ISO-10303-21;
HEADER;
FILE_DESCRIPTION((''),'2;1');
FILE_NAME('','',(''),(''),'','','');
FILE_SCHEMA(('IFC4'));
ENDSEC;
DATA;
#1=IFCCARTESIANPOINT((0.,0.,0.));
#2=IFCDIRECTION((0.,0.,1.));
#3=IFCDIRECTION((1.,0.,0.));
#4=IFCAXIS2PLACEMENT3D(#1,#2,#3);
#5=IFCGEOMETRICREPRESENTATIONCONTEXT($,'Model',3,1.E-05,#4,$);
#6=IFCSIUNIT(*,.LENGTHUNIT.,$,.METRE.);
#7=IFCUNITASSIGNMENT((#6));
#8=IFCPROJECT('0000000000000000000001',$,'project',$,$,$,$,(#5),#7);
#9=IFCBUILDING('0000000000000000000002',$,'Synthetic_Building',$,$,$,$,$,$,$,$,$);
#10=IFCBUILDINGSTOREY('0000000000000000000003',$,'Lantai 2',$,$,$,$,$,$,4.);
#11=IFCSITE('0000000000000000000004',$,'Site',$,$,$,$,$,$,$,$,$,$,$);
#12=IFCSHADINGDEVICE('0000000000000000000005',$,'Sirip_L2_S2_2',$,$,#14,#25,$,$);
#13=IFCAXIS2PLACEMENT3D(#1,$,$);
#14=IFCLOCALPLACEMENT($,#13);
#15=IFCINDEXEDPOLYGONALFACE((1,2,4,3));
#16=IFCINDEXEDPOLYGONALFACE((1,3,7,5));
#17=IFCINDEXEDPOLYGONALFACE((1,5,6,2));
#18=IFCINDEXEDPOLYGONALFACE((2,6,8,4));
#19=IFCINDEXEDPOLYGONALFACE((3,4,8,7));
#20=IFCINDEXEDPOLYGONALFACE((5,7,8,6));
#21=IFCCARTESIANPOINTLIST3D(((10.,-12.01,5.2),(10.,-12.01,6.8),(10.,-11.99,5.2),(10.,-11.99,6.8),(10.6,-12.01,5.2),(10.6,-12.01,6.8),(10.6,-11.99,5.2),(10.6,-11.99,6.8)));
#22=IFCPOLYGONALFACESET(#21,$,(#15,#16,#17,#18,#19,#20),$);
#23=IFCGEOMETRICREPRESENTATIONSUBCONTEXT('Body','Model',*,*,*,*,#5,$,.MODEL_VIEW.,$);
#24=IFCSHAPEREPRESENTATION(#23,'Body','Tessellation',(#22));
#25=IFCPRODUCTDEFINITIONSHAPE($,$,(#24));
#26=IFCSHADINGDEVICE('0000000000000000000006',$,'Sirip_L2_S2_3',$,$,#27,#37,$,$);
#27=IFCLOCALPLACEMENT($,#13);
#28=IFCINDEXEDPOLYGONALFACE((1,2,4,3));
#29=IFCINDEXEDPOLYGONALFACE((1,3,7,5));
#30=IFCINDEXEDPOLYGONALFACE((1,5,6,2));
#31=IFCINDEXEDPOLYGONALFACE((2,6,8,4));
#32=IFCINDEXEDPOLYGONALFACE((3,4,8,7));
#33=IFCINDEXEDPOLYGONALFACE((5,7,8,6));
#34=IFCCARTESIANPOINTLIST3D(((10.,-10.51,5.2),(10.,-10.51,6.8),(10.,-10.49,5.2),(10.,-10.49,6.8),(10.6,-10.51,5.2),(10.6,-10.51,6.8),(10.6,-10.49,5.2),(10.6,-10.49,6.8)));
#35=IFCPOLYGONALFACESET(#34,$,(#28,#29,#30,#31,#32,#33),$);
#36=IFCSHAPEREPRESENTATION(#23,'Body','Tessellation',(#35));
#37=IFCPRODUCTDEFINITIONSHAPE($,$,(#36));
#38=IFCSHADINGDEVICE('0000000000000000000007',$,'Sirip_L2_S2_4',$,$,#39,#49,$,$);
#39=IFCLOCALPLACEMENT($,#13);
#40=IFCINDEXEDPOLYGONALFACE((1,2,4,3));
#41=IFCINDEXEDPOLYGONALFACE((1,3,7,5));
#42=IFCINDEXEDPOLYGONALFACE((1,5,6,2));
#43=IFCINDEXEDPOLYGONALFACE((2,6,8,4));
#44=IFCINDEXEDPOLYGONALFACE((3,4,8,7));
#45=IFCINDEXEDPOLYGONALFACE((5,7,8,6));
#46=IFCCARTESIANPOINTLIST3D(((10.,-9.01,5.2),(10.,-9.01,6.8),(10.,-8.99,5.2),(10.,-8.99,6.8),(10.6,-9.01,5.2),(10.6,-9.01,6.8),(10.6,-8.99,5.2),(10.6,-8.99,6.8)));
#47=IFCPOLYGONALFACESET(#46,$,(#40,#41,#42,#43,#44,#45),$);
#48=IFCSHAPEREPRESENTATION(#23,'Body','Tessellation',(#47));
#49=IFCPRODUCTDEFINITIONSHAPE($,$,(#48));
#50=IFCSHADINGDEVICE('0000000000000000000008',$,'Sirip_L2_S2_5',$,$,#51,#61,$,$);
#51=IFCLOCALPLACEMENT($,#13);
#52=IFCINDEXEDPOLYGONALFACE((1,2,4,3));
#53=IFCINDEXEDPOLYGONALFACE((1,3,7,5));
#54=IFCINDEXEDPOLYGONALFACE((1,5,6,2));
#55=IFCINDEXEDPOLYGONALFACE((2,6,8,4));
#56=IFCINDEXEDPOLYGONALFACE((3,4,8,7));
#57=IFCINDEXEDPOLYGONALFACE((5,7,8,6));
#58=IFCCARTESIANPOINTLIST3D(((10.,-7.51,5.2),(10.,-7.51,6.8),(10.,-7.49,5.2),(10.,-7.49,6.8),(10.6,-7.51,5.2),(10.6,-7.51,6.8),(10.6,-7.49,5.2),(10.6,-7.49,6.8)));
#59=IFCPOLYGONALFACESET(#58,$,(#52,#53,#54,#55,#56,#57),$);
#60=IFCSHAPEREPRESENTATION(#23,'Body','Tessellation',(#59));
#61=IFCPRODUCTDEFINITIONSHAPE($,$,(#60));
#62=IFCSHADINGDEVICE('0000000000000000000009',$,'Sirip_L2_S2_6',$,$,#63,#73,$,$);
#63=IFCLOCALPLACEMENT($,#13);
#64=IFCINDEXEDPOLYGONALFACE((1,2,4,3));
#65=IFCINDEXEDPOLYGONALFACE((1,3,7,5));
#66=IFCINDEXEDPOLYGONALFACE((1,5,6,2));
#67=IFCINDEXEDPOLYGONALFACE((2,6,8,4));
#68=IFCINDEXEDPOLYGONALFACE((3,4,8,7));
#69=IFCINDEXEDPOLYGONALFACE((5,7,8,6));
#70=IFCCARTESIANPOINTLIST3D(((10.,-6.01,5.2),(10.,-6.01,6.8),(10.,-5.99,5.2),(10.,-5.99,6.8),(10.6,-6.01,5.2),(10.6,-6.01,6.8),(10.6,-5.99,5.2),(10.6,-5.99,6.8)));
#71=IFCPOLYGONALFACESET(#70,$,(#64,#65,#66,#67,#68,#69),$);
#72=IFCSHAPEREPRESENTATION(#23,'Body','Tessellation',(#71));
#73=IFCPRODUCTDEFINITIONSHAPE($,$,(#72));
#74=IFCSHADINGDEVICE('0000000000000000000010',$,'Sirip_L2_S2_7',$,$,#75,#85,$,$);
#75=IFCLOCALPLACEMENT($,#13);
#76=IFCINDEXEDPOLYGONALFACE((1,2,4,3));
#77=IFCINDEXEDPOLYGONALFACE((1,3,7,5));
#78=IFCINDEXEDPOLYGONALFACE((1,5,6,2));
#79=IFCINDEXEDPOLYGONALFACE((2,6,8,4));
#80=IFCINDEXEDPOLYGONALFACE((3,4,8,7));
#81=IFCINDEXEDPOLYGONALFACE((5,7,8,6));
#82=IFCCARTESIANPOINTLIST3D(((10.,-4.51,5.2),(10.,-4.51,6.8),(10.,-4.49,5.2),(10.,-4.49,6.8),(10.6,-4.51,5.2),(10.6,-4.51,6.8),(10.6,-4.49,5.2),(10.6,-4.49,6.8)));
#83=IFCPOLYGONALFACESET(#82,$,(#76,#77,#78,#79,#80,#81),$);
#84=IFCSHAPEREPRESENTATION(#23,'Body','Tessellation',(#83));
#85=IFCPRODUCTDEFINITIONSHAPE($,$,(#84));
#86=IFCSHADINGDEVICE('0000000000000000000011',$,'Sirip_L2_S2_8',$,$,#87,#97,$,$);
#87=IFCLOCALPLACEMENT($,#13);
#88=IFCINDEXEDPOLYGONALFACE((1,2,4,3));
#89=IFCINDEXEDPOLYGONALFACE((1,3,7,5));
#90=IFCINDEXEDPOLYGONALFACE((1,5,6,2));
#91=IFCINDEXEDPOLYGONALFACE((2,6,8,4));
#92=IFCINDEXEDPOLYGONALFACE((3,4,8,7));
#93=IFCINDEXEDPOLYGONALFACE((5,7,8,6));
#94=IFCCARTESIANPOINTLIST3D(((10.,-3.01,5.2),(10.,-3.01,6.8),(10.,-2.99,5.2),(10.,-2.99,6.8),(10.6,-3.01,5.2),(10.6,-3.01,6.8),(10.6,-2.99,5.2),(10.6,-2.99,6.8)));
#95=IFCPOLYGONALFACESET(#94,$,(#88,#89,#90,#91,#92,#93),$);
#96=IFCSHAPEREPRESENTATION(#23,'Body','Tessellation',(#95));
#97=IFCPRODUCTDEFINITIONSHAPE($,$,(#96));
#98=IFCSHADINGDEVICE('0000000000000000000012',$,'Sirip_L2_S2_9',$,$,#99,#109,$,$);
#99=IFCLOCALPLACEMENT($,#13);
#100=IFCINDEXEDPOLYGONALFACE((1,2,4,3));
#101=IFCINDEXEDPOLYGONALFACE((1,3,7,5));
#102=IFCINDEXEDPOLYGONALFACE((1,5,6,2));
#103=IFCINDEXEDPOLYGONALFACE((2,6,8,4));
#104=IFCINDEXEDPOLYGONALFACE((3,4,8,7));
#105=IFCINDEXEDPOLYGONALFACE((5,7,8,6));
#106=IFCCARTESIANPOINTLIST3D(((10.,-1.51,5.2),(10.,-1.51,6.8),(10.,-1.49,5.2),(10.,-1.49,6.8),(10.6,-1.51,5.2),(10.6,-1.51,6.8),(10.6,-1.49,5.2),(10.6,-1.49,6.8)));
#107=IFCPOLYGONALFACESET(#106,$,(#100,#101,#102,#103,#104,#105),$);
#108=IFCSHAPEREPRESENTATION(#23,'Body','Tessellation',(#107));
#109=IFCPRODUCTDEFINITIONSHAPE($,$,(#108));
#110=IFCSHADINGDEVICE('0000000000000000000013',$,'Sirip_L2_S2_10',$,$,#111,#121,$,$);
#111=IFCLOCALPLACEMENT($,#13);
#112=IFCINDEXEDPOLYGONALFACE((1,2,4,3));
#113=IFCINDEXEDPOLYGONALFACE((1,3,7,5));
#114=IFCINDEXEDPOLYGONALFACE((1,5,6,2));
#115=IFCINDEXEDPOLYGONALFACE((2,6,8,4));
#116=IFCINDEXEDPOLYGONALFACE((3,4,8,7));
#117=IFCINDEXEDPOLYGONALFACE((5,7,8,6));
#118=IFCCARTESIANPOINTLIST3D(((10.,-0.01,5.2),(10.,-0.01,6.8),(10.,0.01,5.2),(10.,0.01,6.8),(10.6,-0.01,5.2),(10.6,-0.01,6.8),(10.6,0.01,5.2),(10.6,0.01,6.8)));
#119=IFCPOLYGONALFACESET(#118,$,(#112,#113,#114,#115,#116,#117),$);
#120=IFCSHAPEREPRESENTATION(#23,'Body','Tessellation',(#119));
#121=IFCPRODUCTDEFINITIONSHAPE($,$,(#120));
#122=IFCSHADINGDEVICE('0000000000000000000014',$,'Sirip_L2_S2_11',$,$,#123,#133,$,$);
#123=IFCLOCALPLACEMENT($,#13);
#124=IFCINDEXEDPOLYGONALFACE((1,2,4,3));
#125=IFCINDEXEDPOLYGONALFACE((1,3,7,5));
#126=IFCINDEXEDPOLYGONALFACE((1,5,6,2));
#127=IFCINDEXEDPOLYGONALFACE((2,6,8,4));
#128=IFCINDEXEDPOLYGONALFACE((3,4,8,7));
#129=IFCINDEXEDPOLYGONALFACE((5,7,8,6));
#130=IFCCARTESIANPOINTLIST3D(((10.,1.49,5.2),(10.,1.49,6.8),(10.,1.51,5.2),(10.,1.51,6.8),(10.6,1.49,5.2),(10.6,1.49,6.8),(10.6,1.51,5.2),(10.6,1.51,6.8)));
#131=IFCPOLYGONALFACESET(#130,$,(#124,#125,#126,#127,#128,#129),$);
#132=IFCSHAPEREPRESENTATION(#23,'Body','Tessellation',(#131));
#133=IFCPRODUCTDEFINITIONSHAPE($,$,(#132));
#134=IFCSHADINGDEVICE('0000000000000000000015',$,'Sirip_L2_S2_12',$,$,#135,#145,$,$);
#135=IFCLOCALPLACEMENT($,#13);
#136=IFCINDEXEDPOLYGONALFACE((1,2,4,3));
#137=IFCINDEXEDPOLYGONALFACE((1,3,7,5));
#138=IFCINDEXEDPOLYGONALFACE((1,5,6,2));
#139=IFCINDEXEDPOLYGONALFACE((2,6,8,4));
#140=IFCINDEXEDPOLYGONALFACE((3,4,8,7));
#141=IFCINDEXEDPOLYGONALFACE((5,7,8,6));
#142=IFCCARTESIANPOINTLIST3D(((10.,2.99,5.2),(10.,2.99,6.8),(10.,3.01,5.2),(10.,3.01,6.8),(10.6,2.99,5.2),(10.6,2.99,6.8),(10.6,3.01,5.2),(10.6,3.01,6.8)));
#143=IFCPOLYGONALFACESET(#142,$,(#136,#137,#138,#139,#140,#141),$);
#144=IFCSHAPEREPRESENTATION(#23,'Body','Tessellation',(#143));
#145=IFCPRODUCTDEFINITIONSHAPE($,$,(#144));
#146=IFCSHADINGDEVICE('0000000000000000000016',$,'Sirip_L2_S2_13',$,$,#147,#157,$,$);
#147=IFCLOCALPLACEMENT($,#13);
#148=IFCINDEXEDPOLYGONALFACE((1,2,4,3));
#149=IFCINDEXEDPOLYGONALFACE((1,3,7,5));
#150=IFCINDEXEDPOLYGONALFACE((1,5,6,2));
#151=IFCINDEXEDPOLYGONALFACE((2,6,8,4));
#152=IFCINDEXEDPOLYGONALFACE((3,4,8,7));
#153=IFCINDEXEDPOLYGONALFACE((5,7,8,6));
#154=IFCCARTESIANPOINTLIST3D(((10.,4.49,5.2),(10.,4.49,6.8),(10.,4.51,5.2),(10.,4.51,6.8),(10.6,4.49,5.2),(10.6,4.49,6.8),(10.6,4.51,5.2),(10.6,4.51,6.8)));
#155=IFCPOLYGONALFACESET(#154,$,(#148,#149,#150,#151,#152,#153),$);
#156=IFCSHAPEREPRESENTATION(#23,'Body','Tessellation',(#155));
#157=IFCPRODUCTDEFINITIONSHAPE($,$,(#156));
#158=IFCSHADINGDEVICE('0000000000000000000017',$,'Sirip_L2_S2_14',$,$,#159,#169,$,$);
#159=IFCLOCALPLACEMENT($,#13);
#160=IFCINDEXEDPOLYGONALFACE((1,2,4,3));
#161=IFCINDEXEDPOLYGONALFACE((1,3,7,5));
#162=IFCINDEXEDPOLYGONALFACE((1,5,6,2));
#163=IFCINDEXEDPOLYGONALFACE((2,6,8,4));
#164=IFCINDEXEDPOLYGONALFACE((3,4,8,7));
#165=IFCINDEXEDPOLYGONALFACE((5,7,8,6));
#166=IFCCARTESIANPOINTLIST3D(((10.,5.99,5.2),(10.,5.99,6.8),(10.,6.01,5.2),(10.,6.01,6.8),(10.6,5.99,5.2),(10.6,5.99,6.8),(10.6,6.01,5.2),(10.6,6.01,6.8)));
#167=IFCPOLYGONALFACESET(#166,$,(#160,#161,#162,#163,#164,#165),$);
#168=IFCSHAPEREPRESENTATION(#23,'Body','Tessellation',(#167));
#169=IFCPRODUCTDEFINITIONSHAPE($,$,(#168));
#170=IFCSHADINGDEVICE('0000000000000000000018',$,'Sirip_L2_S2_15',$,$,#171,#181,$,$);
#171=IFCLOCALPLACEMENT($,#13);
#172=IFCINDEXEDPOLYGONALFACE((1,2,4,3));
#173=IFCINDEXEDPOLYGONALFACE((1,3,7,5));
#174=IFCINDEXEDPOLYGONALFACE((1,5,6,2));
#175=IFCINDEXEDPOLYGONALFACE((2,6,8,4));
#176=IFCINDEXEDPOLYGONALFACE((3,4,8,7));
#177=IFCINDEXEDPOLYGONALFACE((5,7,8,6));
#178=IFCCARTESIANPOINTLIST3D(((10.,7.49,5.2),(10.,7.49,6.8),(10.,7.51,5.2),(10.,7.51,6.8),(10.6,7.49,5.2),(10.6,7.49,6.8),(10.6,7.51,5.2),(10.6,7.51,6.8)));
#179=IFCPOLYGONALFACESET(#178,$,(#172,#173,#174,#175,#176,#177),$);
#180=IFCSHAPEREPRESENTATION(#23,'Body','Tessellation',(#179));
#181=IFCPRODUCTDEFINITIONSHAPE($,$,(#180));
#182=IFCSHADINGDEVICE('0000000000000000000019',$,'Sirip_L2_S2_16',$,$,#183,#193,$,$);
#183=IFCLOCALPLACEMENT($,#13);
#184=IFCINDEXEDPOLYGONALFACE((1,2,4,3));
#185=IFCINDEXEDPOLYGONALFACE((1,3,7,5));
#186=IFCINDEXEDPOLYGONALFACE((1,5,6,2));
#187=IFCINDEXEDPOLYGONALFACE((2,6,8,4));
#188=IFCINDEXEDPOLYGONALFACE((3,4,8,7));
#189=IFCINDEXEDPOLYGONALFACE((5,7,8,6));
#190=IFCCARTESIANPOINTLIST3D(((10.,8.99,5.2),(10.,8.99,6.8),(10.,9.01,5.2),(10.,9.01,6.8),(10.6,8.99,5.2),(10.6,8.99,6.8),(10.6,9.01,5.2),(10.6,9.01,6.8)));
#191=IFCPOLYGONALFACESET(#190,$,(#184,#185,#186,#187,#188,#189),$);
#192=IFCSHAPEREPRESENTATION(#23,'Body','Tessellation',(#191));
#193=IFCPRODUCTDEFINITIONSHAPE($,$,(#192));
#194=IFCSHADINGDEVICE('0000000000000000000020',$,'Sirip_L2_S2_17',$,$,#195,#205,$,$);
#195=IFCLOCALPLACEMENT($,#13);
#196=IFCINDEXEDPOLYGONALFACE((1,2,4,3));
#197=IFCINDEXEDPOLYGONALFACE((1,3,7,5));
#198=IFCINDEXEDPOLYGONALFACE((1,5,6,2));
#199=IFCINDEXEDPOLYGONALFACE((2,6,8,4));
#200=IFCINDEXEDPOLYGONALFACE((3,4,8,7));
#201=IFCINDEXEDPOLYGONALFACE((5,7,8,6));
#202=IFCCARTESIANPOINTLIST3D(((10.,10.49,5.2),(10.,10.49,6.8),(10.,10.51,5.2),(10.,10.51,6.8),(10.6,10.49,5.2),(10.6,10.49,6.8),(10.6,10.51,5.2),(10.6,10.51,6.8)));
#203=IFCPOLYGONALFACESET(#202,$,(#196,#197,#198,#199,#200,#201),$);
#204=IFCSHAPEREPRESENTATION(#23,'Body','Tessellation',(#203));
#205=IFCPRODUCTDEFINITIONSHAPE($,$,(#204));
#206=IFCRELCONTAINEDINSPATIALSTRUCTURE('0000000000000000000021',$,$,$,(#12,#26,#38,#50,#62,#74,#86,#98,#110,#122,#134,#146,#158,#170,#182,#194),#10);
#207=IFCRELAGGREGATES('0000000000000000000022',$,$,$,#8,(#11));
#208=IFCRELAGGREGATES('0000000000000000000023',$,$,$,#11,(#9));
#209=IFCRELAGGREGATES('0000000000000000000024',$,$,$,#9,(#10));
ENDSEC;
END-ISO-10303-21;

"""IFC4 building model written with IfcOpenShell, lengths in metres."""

from ifc_helpers import new_model, si_unit, frame, origin_with_axes, place, context, subcontext, project, spatial, polyline, outline, extrude, element, save


model = new_model("IFC4")

# Units and contexts
model_context = context("Model", 3, precision=1e-05, world=origin_with_axes())
body_context = subcontext(model_context, "Body", "Model", "MODEL_VIEW")
ifc_project = project(units=[si_unit("LENGTHUNIT", "METRE")], contexts=[model_context])

# Site, building, storey
site = spatial("IfcSite", under=ifc_project, Name="Site")
building = spatial("IfcBuilding", under=site, Name="Synthetic_Building")
storey = spatial("IfcBuildingStorey", under=building, Name="Lantai 2", Elevation=4.0)

# Shading devices
shading_device_1_placement = place(None, origin_with_axes())
element("IfcShadingDevice", 1, at=shading_device_1_placement, inside=storey, Name="Sirip_L2_S2_2", context=body_context, shape_type="SweptSolid", body=[
    extrude(outline(polyline([(10.0, -12.01), (10.0, -11.99), (10.6, -11.99), (10.6, -12.01), (10.0, -12.01)])), frame((0.0, 0.0, 5.2), z_axis=(0.0, 0.0, 1.0), x_axis=(1.0, 0.0, 0.0)), (0.0, 0.0, 1.0), 1.6),
])
shading_device_2_placement = place(None, origin_with_axes())
element("IfcShadingDevice", 2, at=shading_device_2_placement, inside=storey, Name="Sirip_L2_S2_3", context=body_context, shape_type="SweptSolid", body=[
    extrude(outline(polyline([(10.0, -10.51), (10.0, -10.49), (10.6, -10.49), (10.6, -10.51), (10.0, -10.51)])), frame((0.0, 0.0, 5.2), z_axis=(0.0, 0.0, 1.0), x_axis=(1.0, 0.0, 0.0)), (0.0, 0.0, 1.0), 1.6),
])
shading_device_3_placement = place(None, origin_with_axes())
element("IfcShadingDevice", 3, at=shading_device_3_placement, inside=storey, Name="Sirip_L2_S2_4", context=body_context, shape_type="SweptSolid", body=[
    extrude(outline(polyline([(10.0, -9.01), (10.0, -8.99), (10.6, -8.99), (10.6, -9.01), (10.0, -9.01)])), frame((0.0, 0.0, 5.2), z_axis=(0.0, 0.0, 1.0), x_axis=(1.0, 0.0, 0.0)), (0.0, 0.0, 1.0), 1.6),
])
shading_device_4_placement = place(None, origin_with_axes())
element("IfcShadingDevice", 4, at=shading_device_4_placement, inside=storey, Name="Sirip_L2_S2_5", context=body_context, shape_type="SweptSolid", body=[
    extrude(outline(polyline([(10.0, -7.51), (10.0, -7.49), (10.6, -7.49), (10.6, -7.51), (10.0, -7.51)])), frame((0.0, 0.0, 5.2), z_axis=(0.0, 0.0, 1.0), x_axis=(1.0, 0.0, 0.0)), (0.0, 0.0, 1.0), 1.6),
])
shading_device_5_placement = place(None, origin_with_axes())
element("IfcShadingDevice", 5, at=shading_device_5_placement, inside=storey, Name="Sirip_L2_S2_6", context=body_context, shape_type="SweptSolid", body=[
    extrude(outline(polyline([(10.0, -6.01), (10.0, -5.99), (10.6, -5.99), (10.6, -6.01), (10.0, -6.01)])), frame((0.0, 0.0, 5.2), z_axis=(0.0, 0.0, 1.0), x_axis=(1.0, 0.0, 0.0)), (0.0, 0.0, 1.0), 1.6),
])
shading_device_6_placement = place(None, origin_with_axes())
element("IfcShadingDevice", 6, at=shading_device_6_placement, inside=storey, Name="Sirip_L2_S2_7", context=body_context, shape_type="SweptSolid", body=[
    extrude(outline(polyline([(10.0, -4.51), (10.0, -4.49), (10.6, -4.49), (10.6, -4.51), (10.0, -4.51)])), frame((0.0, 0.0, 5.2), z_axis=(0.0, 0.0, 1.0), x_axis=(1.0, 0.0, 0.0)), (0.0, 0.0, 1.0), 1.6),
])
shading_device_7_placement = place(None, origin_with_axes())
element("IfcShadingDevice", 7, at=shading_device_7_placement, inside=storey, Name="Sirip_L2_S2_8", context=body_context, shape_type="SweptSolid", body=[
    extrude(outline(polyline([(10.0, -3.01), (10.0, -2.99), (10.6, -2.99), (10.6, -3.01), (10.0, -3.01)])), frame((0.0, 0.0, 5.2), z_axis=(0.0, 0.0, 1.0), x_axis=(1.0, 0.0, 0.0)), (0.0, 0.0, 1.0), 1.6),
])
shading_device_8_placement = place(None, origin_with_axes())
element("IfcShadingDevice", 8, at=shading_device_8_placement, inside=storey, Name="Sirip_L2_S2_9", context=body_context, shape_type="SweptSolid", body=[
    extrude(outline(polyline([(10.0, -1.51), (10.0, -1.49), (10.6, -1.49), (10.6, -1.51), (10.0, -1.51)])), frame((0.0, 0.0, 5.2), z_axis=(0.0, 0.0, 1.0), x_axis=(1.0, 0.0, 0.0)), (0.0, 0.0, 1.0), 1.6),
])
shading_device_9_placement = place(None, origin_with_axes())
element("IfcShadingDevice", 9, at=shading_device_9_placement, inside=storey, Name="Sirip_L2_S2_10", context=body_context, shape_type="SweptSolid", body=[
    extrude(outline(polyline([(10.0, -0.01), (10.0, 0.01), (10.6, 0.01), (10.6, -0.01), (10.0, -0.01)])), frame((0.0, 0.0, 5.2), z_axis=(0.0, 0.0, 1.0), x_axis=(1.0, 0.0, 0.0)), (0.0, 0.0, 1.0), 1.6),
])
shading_device_10_placement = place(None, origin_with_axes())
element("IfcShadingDevice", 10, at=shading_device_10_placement, inside=storey, Name="Sirip_L2_S2_11", context=body_context, shape_type="SweptSolid", body=[
    extrude(outline(polyline([(10.0, 1.49), (10.0, 1.51), (10.6, 1.51), (10.6, 1.49), (10.0, 1.49)])), frame((0.0, 0.0, 5.2), z_axis=(0.0, 0.0, 1.0), x_axis=(1.0, 0.0, 0.0)), (0.0, 0.0, 1.0), 1.6),
])
shading_device_11_placement = place(None, origin_with_axes())
element("IfcShadingDevice", 11, at=shading_device_11_placement, inside=storey, Name="Sirip_L2_S2_12", context=body_context, shape_type="SweptSolid", body=[
    extrude(outline(polyline([(10.0, 2.99), (10.0, 3.01), (10.6, 3.01), (10.6, 2.99), (10.0, 2.99)])), frame((0.0, 0.0, 5.2), z_axis=(0.0, 0.0, 1.0), x_axis=(1.0, 0.0, 0.0)), (0.0, 0.0, 1.0), 1.6),
])
shading_device_12_placement = place(None, origin_with_axes())
element("IfcShadingDevice", 12, at=shading_device_12_placement, inside=storey, Name="Sirip_L2_S2_13", context=body_context, shape_type="SweptSolid", body=[
    extrude(outline(polyline([(10.0, 4.49), (10.0, 4.51), (10.6, 4.51), (10.6, 4.49), (10.0, 4.49)])), frame((0.0, 0.0, 5.2), z_axis=(0.0, 0.0, 1.0), x_axis=(1.0, 0.0, 0.0)), (0.0, 0.0, 1.0), 1.6),
])
shading_device_13_placement = place(None, origin_with_axes())
element("IfcShadingDevice", 13, at=shading_device_13_placement, inside=storey, Name="Sirip_L2_S2_14", context=body_context, shape_type="SweptSolid", body=[
    extrude(outline(polyline([(10.0, 5.99), (10.0, 6.01), (10.6, 6.01), (10.6, 5.99), (10.0, 5.99)])), frame((0.0, 0.0, 5.2), z_axis=(0.0, 0.0, 1.0), x_axis=(1.0, 0.0, 0.0)), (0.0, 0.0, 1.0), 1.6),
])
shading_device_14_placement = place(None, origin_with_axes())
element("IfcShadingDevice", 14, at=shading_device_14_placement, inside=storey, Name="Sirip_L2_S2_15", context=body_context, shape_type="SweptSolid", body=[
    extrude(outline(polyline([(10.0, 7.49), (10.0, 7.51), (10.6, 7.51), (10.6, 7.49), (10.0, 7.49)])), frame((0.0, 0.0, 5.2), z_axis=(0.0, 0.0, 1.0), x_axis=(1.0, 0.0, 0.0)), (0.0, 0.0, 1.0), 1.6),
])
shading_device_15_placement = place(None, origin_with_axes())
element("IfcShadingDevice", 15, at=shading_device_15_placement, inside=storey, Name="Sirip_L2_S2_16", context=body_context, shape_type="SweptSolid", body=[
    extrude(outline(polyline([(10.0, 8.99), (10.0, 9.01), (10.6, 9.01), (10.6, 8.99), (10.0, 8.99)])), frame((0.0, 0.0, 5.2), z_axis=(0.0, 0.0, 1.0), x_axis=(1.0, 0.0, 0.0)), (0.0, 0.0, 1.0), 1.6),
])
shading_device_16_placement = place(None, origin_with_axes())
element("IfcShadingDevice", 16, at=shading_device_16_placement, inside=storey, Name="Sirip_L2_S2_17", context=body_context, shape_type="SweptSolid", body=[
    extrude(outline(polyline([(10.0, 10.49), (10.0, 10.51), (10.6, 10.51), (10.6, 10.49), (10.0, 10.49)])), frame((0.0, 0.0, 5.2), z_axis=(0.0, 0.0, 1.0), x_axis=(1.0, 0.0, 0.0)), (0.0, 0.0, 1.0), 1.6),
])

save(model, "model.ifc")
